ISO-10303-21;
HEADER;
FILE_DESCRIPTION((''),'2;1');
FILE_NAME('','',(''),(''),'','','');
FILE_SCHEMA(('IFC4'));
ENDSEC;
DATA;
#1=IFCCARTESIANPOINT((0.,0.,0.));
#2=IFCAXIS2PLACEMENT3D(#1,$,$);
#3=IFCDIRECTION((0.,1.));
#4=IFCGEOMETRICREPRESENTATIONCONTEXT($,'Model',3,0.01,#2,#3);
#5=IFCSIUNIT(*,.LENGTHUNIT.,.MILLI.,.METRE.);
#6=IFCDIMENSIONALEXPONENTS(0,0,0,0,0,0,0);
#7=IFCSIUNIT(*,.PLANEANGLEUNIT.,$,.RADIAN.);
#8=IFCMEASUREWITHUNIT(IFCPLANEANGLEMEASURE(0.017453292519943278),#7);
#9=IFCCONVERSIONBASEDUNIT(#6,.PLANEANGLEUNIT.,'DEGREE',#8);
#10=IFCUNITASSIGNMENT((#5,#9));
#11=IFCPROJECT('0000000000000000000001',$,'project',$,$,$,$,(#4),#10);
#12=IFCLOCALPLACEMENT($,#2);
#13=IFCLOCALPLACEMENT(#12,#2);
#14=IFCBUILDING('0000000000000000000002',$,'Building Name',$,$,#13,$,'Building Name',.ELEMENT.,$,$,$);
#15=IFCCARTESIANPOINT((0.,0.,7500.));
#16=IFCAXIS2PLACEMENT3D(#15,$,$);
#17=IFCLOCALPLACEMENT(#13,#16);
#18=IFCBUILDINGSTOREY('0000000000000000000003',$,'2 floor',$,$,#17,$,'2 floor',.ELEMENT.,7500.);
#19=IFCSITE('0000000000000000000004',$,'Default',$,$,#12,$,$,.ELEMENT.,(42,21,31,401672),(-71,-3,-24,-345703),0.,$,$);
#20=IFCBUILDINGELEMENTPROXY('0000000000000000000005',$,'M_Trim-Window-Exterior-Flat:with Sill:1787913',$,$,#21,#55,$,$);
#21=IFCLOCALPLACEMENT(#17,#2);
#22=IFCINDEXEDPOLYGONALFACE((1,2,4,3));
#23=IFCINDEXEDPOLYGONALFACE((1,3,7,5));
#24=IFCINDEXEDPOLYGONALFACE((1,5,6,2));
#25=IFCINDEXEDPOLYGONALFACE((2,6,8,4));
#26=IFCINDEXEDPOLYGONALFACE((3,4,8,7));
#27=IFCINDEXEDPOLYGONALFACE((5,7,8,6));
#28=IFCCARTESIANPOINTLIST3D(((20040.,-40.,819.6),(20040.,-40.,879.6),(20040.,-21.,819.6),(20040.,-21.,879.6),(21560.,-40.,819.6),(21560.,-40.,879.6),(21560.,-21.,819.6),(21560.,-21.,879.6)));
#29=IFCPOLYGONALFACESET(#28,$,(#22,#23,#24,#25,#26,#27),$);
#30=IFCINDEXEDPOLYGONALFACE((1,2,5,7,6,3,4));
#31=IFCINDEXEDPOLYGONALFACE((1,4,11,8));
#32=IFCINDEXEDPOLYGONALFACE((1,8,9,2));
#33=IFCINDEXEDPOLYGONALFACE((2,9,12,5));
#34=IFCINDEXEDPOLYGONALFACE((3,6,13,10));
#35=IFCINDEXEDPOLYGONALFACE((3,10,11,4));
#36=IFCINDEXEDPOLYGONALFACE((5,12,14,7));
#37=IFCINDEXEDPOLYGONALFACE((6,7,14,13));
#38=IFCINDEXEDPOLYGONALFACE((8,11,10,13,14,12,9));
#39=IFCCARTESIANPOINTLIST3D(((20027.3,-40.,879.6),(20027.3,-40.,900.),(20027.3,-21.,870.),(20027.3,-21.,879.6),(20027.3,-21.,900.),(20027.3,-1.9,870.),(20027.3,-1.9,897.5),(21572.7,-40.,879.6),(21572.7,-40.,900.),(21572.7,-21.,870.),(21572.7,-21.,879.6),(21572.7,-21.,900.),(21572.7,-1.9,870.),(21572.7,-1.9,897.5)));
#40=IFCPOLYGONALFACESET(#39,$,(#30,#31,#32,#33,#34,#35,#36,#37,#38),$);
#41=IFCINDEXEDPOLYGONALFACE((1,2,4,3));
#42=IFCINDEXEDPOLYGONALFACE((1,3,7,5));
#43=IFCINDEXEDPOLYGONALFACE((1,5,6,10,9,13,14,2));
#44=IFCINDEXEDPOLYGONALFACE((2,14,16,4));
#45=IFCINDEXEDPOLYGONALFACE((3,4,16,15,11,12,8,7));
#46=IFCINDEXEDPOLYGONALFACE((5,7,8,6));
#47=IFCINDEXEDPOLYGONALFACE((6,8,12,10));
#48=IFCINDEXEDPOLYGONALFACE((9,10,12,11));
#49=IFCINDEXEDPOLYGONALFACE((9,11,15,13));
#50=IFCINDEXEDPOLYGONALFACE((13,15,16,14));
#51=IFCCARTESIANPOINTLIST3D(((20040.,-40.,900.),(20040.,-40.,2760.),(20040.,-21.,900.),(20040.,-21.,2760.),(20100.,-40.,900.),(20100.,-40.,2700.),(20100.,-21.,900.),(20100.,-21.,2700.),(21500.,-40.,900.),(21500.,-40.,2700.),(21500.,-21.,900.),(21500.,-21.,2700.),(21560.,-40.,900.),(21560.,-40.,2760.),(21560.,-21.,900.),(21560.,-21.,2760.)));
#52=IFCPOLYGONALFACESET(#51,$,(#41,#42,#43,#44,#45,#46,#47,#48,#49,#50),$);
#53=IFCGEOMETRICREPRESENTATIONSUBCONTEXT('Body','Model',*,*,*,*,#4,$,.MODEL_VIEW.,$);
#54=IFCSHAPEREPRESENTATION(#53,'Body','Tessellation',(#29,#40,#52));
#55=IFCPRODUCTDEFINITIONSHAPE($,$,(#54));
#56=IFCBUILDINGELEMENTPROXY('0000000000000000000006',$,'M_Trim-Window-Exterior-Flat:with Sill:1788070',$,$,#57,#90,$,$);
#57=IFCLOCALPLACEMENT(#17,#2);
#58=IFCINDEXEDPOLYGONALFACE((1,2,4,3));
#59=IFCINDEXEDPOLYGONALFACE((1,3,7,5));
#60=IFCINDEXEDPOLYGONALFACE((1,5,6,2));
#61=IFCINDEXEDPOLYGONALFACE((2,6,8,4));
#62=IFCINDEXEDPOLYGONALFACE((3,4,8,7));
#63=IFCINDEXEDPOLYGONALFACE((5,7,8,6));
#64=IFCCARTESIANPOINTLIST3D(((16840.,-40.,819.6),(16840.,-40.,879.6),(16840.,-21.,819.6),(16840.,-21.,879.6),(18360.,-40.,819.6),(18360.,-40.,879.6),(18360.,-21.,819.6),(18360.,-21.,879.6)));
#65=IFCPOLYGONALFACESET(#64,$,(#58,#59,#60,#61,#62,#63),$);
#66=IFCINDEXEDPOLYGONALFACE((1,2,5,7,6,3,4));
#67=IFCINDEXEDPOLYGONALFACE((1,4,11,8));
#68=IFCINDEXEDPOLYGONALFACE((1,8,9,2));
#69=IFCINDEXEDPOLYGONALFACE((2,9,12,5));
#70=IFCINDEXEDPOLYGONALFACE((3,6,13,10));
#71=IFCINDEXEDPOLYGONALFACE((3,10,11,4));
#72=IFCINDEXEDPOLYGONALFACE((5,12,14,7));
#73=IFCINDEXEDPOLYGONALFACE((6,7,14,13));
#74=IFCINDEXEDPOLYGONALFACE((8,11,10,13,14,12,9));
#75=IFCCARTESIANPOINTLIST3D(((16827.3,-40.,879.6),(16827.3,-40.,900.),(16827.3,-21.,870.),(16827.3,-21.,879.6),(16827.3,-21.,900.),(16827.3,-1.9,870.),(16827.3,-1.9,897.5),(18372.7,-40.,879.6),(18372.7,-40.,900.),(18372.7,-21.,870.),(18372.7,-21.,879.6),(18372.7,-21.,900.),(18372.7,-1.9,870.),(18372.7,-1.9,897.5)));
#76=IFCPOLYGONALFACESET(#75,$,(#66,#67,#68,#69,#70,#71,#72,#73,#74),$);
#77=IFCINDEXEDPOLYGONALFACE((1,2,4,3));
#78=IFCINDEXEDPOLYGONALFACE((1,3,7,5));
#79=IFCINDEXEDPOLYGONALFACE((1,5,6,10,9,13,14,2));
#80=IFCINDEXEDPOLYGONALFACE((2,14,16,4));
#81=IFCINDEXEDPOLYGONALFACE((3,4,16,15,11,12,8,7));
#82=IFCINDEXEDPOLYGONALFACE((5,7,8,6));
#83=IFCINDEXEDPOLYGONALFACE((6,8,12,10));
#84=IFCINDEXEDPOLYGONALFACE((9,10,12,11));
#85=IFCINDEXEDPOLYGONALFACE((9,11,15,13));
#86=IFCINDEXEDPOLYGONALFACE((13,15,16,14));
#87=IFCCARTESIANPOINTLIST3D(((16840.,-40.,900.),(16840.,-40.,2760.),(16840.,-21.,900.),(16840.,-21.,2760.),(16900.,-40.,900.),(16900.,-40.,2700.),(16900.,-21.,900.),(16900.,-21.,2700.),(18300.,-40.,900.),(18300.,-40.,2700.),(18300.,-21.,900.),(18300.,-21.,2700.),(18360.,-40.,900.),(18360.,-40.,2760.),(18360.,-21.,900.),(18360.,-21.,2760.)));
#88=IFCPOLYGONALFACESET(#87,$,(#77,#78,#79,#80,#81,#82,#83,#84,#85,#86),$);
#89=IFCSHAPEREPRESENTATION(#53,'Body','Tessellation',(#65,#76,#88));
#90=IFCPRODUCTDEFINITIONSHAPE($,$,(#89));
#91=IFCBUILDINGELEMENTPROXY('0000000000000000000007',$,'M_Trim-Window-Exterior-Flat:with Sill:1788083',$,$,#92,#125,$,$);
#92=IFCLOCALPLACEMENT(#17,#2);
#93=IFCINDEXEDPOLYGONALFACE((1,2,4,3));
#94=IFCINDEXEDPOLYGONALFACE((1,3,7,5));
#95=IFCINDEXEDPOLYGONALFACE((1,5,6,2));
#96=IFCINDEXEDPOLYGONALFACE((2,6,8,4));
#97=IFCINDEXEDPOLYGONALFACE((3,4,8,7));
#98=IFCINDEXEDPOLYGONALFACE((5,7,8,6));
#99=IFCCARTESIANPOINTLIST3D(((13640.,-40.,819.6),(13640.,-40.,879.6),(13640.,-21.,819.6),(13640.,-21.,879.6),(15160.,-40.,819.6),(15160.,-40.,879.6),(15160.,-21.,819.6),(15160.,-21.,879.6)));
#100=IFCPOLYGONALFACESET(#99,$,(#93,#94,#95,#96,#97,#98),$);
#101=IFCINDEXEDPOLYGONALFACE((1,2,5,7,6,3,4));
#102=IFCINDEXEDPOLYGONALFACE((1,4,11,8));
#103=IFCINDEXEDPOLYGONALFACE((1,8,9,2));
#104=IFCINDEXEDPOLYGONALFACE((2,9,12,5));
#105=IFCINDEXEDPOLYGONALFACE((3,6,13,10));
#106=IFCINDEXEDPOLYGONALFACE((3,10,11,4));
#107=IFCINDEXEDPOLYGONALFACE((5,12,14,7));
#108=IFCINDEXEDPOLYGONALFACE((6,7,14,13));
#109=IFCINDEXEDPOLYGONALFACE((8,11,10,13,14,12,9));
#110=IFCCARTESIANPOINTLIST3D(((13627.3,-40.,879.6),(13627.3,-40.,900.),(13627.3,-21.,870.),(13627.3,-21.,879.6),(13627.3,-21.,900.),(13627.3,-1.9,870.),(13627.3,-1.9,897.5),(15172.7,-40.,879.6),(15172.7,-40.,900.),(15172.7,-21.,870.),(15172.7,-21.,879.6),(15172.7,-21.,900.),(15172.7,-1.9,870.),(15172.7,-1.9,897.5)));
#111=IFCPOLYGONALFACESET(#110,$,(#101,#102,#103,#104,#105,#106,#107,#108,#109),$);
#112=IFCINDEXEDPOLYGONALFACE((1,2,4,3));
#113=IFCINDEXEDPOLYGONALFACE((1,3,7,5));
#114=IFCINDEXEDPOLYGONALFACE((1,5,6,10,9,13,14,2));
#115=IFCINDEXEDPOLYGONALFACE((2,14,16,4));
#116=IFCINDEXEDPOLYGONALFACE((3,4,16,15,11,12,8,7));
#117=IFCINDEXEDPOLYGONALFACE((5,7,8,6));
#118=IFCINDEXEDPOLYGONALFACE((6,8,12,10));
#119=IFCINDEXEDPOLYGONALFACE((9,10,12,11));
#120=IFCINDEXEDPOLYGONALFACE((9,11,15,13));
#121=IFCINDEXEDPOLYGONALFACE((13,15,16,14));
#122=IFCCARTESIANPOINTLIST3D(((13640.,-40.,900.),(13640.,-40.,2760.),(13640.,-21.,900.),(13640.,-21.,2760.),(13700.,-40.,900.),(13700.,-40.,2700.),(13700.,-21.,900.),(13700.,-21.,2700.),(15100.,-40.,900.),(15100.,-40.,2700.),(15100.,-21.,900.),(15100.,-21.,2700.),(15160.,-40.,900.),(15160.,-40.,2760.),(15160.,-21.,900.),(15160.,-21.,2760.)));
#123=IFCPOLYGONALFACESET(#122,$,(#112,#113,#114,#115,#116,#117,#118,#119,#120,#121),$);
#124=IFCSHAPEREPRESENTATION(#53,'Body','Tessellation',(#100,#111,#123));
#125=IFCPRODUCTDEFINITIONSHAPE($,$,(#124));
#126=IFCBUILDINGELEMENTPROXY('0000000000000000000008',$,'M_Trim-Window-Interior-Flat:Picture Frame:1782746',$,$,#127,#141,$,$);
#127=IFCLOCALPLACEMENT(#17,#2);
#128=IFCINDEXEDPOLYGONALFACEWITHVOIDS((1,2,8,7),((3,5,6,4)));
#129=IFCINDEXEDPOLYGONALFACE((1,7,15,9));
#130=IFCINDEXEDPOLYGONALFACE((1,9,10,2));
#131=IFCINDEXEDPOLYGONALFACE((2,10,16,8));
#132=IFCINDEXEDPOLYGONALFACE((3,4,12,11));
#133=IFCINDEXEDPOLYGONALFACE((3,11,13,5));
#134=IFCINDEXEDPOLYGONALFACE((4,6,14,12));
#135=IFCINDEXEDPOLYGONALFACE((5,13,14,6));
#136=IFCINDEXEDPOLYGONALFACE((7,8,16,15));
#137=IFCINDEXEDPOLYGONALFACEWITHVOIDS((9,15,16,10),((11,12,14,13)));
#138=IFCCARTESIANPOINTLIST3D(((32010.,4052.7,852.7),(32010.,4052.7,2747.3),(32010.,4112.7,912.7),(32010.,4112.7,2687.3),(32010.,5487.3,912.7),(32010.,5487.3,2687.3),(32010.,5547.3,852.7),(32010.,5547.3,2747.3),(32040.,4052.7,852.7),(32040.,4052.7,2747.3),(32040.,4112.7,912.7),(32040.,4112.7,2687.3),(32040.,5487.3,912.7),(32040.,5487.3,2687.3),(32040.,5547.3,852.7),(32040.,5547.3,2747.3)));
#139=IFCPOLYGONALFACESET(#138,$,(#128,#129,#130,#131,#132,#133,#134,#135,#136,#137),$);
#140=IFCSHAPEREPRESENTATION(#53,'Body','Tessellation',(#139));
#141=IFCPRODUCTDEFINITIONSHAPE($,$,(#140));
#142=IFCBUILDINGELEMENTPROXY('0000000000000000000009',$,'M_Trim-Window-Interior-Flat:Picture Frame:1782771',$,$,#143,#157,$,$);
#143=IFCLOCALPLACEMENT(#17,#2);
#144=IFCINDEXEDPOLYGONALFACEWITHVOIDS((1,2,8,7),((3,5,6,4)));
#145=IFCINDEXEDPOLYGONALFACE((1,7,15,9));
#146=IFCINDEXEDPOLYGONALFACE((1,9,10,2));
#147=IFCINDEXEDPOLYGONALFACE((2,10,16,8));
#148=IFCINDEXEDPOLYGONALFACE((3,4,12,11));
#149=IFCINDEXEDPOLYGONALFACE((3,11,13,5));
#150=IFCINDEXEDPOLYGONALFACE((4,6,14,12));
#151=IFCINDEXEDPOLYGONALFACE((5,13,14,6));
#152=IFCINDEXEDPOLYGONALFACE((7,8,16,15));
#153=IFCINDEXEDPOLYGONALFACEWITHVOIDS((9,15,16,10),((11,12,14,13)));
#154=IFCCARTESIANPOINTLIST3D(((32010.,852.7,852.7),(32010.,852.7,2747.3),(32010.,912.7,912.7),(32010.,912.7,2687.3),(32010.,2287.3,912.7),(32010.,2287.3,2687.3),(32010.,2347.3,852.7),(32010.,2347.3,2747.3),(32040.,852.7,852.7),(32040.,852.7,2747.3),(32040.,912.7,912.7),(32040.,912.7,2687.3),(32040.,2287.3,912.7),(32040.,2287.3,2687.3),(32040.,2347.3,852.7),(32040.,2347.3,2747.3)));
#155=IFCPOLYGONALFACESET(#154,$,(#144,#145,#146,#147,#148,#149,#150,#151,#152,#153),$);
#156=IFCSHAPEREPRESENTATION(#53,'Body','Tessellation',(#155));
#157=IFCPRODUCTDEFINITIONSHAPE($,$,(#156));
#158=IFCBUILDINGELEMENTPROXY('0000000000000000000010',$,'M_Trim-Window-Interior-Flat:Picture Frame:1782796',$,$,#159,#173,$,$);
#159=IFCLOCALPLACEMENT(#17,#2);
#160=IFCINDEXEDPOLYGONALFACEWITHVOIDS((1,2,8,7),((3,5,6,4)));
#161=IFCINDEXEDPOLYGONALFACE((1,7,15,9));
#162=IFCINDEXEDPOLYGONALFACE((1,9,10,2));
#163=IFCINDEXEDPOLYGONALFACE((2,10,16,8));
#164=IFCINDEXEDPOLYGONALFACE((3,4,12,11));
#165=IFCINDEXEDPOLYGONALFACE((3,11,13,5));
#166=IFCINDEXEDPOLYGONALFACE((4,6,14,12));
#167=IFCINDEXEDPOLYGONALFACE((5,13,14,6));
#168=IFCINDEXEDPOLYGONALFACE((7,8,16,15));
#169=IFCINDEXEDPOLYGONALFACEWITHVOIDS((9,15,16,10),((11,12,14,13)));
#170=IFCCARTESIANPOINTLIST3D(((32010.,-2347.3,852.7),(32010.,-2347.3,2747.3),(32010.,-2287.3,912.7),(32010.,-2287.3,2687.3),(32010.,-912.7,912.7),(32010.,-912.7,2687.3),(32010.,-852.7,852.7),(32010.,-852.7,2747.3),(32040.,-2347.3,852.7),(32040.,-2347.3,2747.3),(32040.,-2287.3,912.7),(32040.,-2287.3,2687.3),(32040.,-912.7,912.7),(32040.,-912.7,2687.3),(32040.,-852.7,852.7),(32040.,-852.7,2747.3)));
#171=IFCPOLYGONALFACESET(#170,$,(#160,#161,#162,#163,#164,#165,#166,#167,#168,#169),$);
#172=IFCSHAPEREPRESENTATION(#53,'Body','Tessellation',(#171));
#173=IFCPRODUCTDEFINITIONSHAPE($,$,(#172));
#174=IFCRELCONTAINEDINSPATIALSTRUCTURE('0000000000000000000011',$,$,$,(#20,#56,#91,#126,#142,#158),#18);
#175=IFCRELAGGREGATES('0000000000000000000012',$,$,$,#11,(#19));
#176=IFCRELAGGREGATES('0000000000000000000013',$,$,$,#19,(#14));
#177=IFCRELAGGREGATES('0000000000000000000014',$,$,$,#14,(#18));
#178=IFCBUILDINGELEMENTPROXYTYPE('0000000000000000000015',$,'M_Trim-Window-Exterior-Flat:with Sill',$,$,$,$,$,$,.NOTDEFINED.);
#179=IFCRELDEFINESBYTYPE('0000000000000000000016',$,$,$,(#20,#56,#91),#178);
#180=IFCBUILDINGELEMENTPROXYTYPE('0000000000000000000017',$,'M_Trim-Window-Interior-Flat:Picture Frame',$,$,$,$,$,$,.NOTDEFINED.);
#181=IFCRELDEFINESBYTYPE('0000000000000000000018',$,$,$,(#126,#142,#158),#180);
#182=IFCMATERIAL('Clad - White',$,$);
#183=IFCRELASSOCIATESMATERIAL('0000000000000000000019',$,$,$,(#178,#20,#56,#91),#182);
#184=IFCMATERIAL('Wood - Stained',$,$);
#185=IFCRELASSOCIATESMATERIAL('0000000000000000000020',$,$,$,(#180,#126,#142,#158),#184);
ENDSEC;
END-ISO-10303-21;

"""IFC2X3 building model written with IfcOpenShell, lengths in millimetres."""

from ifc_helpers import new_model, entity, si_unit, converted_unit, direction, frame, frame_2d, origin, place, context, subcontext, project, spatial, polyline, rectangle, outline, extrude, source, transform, mapped, material, type_object, type_shapes, element, save


model = new_model("IFC2X3")

# Units and contexts
model_context = context("Model", 3, precision=0.01, world=origin(), true_north=direction((0.0, 1.0)))
body_context = subcontext(model_context, "Body", "Model", "MODEL_VIEW")
ifc_project = project(units=[si_unit("LENGTHUNIT", "METRE", prefix="MILLI"), converted_unit("PLANEANGLEUNIT", "DEGREE", entity("IfcPlaneAngleMeasure", 0.017453292519943278), si_unit("PLANEANGLEUNIT", "RADIAN"), dimensions=[0, 0, 0, 0, 0, 0, 0])], contexts=[model_context])

# Site, building, storey
site_placement = place(None, origin())
site = spatial("IfcSite", under=ifc_project, at=site_placement, Name="Default", CompositionType="ELEMENT", RefLatitude=(42, 21, 31, 401672), RefLongitude=(-71, -3, -24, -345703), RefElevation=0.0)
building_placement = place(site_placement, origin())
building = spatial("IfcBuilding", under=site, at=building_placement, Name="Building Name", LongName="Building Name", CompositionType="ELEMENT")
storey_placement = place(building_placement, frame((0.0, 0.0, 7500.0)))
storey = spatial("IfcBuildingStorey", under=building, at=storey_placement, Name="2 floor", LongName="2 floor", CompositionType="ELEMENT", Elevation=7500.0)

# Building element proxies
ifc_material_1 = material(Name="Clad - White")
ifc_material_2 = material(Name="Wood - Stained")
building_element_proxy_type_1 = type_object("IfcBuildingElementProxyType", Name="M_Trim-Window-Exterior-Flat:with Sill", PredefinedType="NOTDEFINED", material=ifc_material_1)
shared_shape_1 = source(origin(), body_context, "Body", "SweptSolid", [
    extrude(rectangle(XDim=1520.0, YDim=60.0, at=frame_2d((0.0, 0.0), x_axis=(1.0, 0.0))), frame((0.0, -1850.4, 0.0), z_axis=(0.0, 0.0, 1.0), x_axis=(-1.0, 0.0, 0.0)), (0.0, 0.0, 1.0), 19.0),
    extrude(outline(polyline([(-19.0, -15.2), (0.0, -15.2), (0.0, -5.7), (19.0, -5.7), (19.0, 14.8), (0.0, 14.8), (-19.0, 12.3), (-19.0, -15.2)])), frame((-772.7, -1814.8, 19.0), z_axis=(1.0, 0.0, 0.0), x_axis=(0.0, 0.0, -1.0)), (0.0, 0.0, 1.0), 1545.4),
    extrude(outline(polyline([(-945.0, -760.0), (915.0, -760.0), (915.0, -700.0), (-885.0, -700.0), (-885.0, 700.0), (915.0, 700.0), (915.0, 760.0), (-945.0, 760.0), (-945.0, -760.0)])), frame((0.0, -885.0, 0.0), z_axis=(0.0, 0.0, 1.0), x_axis=(0.0, -1.0, 0.0)), (0.0, 0.0, 1.0), 19.0),
])
type_shapes(building_element_proxy_type_1, [shared_shape_1])
for number, where, z_axis, x_axis, name in (
    (1, (20800.0, -40.0, 2700.0), (0.0, 1.0, 0.0), (-1.0, 0.0, 0.0), "M_Trim-Window-Exterior-Flat:with Sill:1787913"),
    (2, (17600.0, -40.0, 2700.0), (0.0, 1.0, 0.0), (-1.0, 0.0, 0.0), "M_Trim-Window-Exterior-Flat:with Sill:1788070"),
    (3, (14400.0, -40.0, 2700.0), (0.0, 1.0, 0.0), (-1.0, 0.0, 0.0), "M_Trim-Window-Exterior-Flat:with Sill:1788083"),
):
    element("IfcBuildingElementProxy", number, at=place(storey_placement, frame(where, z_axis=z_axis, x_axis=x_axis)), inside=storey, type_object=building_element_proxy_type_1, material=ifc_material_1, Name=name, context=body_context, shape_type="MappedRepresentation", body=[
        mapped(shared_shape_1, transform((0.0, 0.0, 0.0), scale=1.0)),
    ])
building_element_proxy_type_2 = type_object("IfcBuildingElementProxyType", Name="M_Trim-Window-Interior-Flat:Picture Frame", PredefinedType="NOTDEFINED", material=ifc_material_2)
shared_shape_2 = source(origin(), body_context, "Body", "SweptSolid", [
    extrude(outline(polyline([(-747.3, -947.3), (747.3, -947.3), (747.3, 947.3), (-747.3, 947.3), (-747.3, -947.3)]), holes=[polyline([(-687.3, -887.3), (-687.3, 887.3), (687.3, 887.3), (687.3, -887.3), (-687.3, -887.3)])]), frame((0.0, -900.0, 0.0), z_axis=(0.0, 0.0, 1.0), x_axis=(-1.0, 0.0, 0.0)), (0.0, 0.0, 1.0), 30.0),
])
type_shapes(building_element_proxy_type_2, [shared_shape_2])
for number, where, z_axis, x_axis, name in (
    (4, (32040.0, 4800.0, 2700.0), (-1.0, 0.0, 0.0), (0.0, -1.0, 0.0), "M_Trim-Window-Interior-Flat:Picture Frame:1782746"),
    (5, (32040.0, 1600.0, 2700.0), (-1.0, 0.0, 0.0), (0.0, -1.0, 0.0), "M_Trim-Window-Interior-Flat:Picture Frame:1782771"),
    (6, (32040.0, -1600.0, 2700.0), (-1.0, 0.0, 0.0), (0.0, -1.0, 0.0), "M_Trim-Window-Interior-Flat:Picture Frame:1782796"),
):
    element("IfcBuildingElementProxy", number, at=place(storey_placement, frame(where, z_axis=z_axis, x_axis=x_axis)), inside=storey, type_object=building_element_proxy_type_2, material=ifc_material_2, Name=name, context=body_context, shape_type="MappedRepresentation", body=[
        mapped(shared_shape_2, transform((0.0, 0.0, 0.0), scale=1.0)),
    ])

save(model, "model.ifc")
